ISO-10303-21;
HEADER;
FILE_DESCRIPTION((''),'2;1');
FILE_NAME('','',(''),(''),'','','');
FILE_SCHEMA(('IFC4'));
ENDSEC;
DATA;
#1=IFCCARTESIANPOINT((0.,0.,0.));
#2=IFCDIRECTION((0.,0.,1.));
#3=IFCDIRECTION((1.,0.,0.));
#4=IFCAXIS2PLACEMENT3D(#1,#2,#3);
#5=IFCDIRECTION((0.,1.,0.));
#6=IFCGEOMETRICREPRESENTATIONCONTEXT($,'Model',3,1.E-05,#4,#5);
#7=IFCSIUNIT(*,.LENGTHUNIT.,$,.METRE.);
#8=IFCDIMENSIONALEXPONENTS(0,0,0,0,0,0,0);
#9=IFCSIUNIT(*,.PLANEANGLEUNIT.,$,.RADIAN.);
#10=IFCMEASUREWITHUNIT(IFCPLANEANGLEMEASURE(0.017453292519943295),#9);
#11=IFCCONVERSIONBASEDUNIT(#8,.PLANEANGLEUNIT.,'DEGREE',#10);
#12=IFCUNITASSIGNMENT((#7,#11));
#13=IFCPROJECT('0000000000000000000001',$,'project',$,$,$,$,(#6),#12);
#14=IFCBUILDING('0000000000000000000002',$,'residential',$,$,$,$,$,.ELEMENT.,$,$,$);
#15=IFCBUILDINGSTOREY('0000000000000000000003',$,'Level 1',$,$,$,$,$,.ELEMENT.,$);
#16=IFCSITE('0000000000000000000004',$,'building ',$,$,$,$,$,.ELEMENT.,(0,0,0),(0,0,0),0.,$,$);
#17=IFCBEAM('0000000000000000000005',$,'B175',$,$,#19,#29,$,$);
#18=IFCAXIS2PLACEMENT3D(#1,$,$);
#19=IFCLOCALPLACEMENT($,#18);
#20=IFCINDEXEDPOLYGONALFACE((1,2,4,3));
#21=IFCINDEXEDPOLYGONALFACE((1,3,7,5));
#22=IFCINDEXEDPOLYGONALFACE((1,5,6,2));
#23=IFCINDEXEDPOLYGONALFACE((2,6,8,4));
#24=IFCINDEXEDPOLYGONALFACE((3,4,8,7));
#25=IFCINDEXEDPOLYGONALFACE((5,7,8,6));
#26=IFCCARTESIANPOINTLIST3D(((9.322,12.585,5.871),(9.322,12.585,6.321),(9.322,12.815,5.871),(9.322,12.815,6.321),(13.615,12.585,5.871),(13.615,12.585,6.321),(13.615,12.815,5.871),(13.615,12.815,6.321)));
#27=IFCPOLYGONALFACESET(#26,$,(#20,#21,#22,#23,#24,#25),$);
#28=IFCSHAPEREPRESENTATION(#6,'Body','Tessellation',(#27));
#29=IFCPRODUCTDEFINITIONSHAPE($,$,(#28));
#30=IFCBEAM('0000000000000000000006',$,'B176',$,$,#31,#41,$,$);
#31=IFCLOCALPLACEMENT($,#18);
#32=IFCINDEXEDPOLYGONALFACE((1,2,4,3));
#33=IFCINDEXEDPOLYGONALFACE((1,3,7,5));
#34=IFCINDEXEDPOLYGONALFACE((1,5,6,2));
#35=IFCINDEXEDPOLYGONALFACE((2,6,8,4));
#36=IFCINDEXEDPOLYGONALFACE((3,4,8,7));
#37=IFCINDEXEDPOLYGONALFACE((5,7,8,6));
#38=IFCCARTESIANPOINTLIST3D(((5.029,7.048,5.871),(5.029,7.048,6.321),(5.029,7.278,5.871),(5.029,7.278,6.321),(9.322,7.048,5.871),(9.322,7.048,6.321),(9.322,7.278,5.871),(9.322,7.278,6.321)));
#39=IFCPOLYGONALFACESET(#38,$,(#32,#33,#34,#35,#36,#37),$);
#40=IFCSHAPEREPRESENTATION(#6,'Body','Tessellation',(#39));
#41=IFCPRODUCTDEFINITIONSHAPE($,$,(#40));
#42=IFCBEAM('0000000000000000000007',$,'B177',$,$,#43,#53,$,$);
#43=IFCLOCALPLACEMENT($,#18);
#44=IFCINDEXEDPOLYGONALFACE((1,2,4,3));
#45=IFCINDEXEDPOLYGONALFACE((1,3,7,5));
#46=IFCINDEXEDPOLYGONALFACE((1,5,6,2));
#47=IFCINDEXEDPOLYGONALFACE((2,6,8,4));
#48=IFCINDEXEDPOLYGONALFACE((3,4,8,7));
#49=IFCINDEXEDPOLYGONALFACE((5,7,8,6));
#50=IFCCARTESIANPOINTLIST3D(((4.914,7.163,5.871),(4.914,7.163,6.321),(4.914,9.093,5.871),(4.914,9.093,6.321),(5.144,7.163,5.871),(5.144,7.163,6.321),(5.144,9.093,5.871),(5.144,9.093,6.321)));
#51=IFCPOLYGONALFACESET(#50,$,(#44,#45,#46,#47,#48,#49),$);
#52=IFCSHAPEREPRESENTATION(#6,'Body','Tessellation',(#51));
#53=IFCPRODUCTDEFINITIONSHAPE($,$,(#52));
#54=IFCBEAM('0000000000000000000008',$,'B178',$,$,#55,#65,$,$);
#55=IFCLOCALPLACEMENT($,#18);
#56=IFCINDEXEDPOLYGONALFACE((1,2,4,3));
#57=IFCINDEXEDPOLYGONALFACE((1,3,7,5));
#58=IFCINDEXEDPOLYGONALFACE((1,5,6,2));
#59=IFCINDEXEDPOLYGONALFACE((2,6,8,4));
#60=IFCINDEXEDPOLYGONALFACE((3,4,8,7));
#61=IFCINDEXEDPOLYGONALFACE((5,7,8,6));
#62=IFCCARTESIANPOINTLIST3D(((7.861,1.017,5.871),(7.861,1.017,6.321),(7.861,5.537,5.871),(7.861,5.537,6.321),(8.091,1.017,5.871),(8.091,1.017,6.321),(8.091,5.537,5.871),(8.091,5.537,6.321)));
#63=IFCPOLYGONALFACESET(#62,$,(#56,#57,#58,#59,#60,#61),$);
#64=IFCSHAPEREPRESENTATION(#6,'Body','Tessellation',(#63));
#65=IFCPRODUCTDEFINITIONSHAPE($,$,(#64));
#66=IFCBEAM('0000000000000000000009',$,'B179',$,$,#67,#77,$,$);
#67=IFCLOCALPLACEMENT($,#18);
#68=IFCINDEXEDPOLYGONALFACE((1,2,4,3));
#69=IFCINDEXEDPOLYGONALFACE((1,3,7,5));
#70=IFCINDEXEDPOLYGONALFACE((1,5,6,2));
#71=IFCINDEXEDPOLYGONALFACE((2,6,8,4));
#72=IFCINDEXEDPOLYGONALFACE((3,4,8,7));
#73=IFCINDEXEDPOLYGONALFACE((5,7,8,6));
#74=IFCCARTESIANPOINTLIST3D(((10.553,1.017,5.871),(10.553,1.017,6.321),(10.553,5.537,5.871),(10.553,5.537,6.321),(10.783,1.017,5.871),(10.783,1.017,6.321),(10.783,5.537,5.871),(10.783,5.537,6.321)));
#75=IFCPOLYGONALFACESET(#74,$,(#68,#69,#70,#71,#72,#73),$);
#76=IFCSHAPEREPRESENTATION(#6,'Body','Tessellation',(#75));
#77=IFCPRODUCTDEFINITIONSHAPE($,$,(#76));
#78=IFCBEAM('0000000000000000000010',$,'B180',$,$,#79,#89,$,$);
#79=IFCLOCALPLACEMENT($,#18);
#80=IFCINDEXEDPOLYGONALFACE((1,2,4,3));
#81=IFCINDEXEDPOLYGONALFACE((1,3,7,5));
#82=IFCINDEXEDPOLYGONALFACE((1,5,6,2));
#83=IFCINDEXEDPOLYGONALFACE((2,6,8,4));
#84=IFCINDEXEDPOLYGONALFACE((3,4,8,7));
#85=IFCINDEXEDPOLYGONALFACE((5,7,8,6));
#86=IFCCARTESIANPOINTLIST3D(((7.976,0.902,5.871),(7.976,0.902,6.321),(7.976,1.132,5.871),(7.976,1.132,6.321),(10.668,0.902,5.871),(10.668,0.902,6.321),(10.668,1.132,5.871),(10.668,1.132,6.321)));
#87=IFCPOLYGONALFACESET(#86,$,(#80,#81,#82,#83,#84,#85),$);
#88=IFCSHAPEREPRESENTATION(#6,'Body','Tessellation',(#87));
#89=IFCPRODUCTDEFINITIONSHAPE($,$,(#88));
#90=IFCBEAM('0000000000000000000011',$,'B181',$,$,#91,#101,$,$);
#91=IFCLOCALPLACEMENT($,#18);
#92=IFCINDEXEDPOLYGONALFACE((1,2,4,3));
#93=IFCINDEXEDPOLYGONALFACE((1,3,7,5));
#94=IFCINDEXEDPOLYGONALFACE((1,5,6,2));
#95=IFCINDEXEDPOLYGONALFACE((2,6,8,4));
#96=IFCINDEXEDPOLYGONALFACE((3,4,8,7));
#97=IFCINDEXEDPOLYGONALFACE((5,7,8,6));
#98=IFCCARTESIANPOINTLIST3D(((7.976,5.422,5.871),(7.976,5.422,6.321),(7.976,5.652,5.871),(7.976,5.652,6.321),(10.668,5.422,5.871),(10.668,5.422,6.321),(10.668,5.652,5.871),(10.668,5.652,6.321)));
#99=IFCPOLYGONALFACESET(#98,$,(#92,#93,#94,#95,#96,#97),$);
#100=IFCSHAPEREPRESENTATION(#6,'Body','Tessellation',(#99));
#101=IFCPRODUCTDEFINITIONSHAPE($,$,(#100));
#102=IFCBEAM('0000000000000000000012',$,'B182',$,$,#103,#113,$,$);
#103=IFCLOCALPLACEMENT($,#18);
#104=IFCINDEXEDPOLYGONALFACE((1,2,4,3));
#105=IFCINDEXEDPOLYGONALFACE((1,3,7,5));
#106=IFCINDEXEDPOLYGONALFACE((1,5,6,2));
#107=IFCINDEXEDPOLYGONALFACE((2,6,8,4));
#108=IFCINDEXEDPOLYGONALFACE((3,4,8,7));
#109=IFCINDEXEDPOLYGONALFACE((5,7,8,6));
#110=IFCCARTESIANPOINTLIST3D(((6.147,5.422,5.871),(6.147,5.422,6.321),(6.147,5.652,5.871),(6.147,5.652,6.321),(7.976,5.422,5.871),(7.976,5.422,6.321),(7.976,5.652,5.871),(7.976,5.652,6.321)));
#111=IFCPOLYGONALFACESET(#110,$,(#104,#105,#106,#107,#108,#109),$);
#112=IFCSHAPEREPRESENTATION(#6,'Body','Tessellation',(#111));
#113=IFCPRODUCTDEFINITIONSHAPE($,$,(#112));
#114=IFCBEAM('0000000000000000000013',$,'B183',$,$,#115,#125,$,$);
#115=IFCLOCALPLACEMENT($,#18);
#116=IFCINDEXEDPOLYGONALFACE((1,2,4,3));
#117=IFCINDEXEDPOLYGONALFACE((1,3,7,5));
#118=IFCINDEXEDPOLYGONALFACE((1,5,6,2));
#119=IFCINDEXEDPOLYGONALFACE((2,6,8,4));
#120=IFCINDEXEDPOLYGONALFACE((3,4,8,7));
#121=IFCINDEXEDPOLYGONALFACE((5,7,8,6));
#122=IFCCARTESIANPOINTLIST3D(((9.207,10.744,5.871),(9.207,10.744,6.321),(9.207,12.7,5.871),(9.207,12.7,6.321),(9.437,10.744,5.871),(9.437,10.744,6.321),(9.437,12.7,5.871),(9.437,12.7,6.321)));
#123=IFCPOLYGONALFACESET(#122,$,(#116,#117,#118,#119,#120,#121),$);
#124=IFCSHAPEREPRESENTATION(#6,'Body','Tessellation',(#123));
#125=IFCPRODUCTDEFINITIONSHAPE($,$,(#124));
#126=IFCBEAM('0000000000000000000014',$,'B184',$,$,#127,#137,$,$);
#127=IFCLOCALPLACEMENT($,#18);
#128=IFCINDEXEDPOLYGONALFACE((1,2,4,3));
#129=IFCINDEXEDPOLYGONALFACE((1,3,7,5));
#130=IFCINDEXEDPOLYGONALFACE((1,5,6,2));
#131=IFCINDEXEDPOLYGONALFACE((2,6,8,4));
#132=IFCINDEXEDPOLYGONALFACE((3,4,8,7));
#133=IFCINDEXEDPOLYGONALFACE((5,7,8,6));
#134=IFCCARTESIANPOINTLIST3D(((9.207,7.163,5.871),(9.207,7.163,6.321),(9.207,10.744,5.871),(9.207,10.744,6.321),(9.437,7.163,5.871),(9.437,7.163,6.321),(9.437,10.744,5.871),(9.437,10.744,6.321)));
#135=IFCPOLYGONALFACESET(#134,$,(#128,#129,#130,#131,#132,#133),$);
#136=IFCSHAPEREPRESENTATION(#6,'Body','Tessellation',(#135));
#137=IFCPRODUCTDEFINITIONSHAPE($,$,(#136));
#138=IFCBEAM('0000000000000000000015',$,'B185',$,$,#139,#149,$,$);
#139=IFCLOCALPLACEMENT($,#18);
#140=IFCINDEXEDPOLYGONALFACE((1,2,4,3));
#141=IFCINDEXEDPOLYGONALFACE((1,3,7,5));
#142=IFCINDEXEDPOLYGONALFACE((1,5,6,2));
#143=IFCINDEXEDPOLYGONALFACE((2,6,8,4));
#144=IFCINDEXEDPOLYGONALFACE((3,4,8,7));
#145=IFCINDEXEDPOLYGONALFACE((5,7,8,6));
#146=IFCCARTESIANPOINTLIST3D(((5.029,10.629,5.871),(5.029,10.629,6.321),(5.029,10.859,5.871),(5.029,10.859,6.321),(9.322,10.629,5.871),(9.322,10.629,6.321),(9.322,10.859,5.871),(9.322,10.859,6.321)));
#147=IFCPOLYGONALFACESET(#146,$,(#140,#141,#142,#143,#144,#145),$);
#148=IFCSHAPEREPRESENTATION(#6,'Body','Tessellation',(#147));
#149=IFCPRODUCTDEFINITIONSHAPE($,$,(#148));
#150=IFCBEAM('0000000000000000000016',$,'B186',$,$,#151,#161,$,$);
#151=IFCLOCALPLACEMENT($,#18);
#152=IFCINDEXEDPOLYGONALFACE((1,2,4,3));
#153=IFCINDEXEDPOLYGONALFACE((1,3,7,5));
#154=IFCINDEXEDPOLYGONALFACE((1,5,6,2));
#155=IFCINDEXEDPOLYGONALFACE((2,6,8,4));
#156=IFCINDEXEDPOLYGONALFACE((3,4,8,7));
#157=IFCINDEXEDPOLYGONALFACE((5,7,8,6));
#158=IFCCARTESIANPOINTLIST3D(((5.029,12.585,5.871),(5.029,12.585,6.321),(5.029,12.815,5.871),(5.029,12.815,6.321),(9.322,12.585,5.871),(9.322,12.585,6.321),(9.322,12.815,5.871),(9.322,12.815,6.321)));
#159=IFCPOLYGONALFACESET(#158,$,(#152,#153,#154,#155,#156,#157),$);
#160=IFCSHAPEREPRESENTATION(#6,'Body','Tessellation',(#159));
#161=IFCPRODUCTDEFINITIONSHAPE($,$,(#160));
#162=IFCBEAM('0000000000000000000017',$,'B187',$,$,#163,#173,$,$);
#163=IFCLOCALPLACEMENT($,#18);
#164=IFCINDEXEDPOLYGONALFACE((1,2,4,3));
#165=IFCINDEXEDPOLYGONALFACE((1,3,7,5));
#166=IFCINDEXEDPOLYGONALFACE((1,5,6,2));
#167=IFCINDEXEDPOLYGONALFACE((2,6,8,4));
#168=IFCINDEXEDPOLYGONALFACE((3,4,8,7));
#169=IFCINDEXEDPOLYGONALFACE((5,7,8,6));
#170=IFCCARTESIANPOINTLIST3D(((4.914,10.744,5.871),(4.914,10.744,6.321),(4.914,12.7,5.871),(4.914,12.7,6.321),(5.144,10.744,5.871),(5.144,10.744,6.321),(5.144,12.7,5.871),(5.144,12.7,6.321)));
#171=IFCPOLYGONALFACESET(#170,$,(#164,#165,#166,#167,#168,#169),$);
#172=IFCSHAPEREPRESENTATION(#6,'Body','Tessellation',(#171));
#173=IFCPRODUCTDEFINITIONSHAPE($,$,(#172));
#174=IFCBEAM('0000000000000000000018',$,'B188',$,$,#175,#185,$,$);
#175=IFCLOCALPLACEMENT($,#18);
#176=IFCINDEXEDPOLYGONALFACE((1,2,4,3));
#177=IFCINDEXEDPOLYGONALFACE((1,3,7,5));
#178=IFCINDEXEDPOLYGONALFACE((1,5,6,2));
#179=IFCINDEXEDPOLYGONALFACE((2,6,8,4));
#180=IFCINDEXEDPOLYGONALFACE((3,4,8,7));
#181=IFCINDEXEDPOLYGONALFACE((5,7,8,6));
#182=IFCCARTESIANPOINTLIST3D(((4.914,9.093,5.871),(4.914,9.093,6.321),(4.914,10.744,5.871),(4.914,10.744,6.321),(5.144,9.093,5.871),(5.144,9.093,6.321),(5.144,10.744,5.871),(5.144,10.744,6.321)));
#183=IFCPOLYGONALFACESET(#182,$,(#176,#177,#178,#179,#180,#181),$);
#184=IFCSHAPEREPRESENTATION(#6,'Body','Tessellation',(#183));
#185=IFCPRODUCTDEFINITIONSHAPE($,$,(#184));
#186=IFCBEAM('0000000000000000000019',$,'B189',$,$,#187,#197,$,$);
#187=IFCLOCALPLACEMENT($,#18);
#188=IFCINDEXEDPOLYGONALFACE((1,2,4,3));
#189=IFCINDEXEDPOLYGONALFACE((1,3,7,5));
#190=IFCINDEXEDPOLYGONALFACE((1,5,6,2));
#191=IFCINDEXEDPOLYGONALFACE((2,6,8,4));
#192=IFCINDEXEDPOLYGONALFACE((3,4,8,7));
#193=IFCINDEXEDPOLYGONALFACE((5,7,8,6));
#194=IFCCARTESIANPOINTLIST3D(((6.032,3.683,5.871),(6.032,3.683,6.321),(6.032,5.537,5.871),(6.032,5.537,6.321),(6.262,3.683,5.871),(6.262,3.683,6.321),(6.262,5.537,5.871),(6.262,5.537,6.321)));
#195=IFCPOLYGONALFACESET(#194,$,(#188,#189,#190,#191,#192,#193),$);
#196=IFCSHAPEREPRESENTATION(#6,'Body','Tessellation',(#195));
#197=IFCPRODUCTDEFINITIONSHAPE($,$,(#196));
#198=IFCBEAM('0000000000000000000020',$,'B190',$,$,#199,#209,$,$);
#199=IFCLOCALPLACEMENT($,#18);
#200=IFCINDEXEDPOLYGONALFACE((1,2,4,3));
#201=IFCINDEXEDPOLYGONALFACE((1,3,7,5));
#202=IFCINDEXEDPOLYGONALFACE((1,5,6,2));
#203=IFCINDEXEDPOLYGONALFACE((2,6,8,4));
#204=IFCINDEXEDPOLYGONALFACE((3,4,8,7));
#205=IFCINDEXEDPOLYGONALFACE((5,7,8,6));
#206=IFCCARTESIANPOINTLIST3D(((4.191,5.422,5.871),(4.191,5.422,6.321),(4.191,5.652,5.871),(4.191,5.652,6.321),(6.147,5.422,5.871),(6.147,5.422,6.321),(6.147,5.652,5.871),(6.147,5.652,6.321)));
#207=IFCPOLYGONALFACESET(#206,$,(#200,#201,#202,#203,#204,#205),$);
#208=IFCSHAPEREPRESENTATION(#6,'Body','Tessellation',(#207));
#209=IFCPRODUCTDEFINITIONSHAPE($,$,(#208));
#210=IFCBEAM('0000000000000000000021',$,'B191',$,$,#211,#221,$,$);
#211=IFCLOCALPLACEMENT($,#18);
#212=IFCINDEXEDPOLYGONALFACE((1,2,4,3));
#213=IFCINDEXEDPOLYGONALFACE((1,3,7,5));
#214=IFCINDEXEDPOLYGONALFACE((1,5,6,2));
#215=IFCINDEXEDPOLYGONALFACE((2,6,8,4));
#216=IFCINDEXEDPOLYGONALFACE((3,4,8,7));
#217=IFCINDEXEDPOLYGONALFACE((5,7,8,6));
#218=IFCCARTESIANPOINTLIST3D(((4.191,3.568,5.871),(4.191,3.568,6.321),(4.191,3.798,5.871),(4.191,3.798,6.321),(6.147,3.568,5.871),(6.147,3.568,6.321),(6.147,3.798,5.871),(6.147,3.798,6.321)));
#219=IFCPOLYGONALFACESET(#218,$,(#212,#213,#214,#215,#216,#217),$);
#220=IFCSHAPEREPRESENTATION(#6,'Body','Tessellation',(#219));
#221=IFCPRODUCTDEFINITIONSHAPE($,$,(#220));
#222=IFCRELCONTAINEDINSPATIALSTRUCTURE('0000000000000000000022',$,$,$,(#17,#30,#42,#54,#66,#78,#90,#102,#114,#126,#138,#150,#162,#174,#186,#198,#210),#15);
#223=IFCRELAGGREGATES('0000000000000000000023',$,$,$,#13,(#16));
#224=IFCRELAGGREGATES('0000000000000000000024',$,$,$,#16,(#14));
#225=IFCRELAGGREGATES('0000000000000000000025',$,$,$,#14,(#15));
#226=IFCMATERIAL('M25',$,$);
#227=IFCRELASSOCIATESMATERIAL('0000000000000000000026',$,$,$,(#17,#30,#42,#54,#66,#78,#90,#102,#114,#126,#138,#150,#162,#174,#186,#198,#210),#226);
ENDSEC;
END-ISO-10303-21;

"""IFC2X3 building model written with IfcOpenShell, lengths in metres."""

from ifc_helpers import new_model, entity, si_unit, converted_unit, direction, frame, frame_2d, origin_with_axes, place, context, project, spatial, rectangle, extrude, material, element, save


model = new_model("IFC2X3")

# Units and contexts
model_context = context("Model", 3, precision=1e-05, world=origin_with_axes(), true_north=direction((0.0, 1.0, 0.0)))
ifc_project = project(units=[si_unit("LENGTHUNIT", "METRE"), converted_unit("PLANEANGLEUNIT", "DEGREE", entity("IfcPlaneAngleMeasure", 0.017453292519943295), si_unit("PLANEANGLEUNIT", "RADIAN"), dimensions=[0, 0, 0, 0, 0, 0, 0])], contexts=[model_context])

# Site, building, storey
site = spatial("IfcSite", under=ifc_project, Name="building ", CompositionType="ELEMENT", RefLatitude=(0, 0, 0), RefLongitude=(0, 0, 0), RefElevation=0.0)
building = spatial("IfcBuilding", under=site, Name="residential", CompositionType="ELEMENT")
storey = spatial("IfcBuildingStorey", under=building, Name="Level 1", CompositionType="ELEMENT")

# Beams
ifc_material = material(Name="M25")
placement = place(None, origin_with_axes())
element("IfcBeam", 1, at=placement, inside=storey, material=ifc_material, Name="B175", context=model_context, shape_type="SweptSolid", body=[
    extrude(rectangle(XDim=0.23, YDim=0.45, at=frame_2d((0.0, 0.0), x_axis=(0.0, 1.0, 0.0))), frame((9.322, 12.7, 6.096), z_axis=(1.0, 0.0, 0.0), x_axis=(0.0, 0.0, -1.0)), (0.0, 0.0, 1.0), 4.293),
])
element("IfcBeam", 2, at=placement, inside=storey, material=ifc_material, Name="B176", context=model_context, shape_type="SweptSolid", body=[
    extrude(rectangle(XDim=0.23, YDim=0.45, at=frame_2d((0.0, 0.0), x_axis=(0.0, 1.0, 0.0))), frame((5.029, 7.163, 6.096), z_axis=(1.0, 0.0, 0.0), x_axis=(0.0, 0.0, -1.0)), (0.0, 0.0, 1.0), 4.293),
])
element("IfcBeam", 3, at=placement, inside=storey, material=ifc_material, Name="B177", context=model_context, shape_type="SweptSolid", body=[
    extrude(rectangle(XDim=0.23, YDim=0.45, at=frame_2d((0.0, 0.0), x_axis=(0.0, 1.0, 0.0))), frame((5.029, 9.093, 6.096), z_axis=(0.0, -1.0, 0.0), x_axis=(0.0, 0.0, -1.0)), (0.0, 0.0, 1.0), 1.93),
])
element("IfcBeam", 4, at=placement, inside=storey, material=ifc_material, Name="B178", context=model_context, shape_type="SweptSolid", body=[
    extrude(rectangle(XDim=0.23, YDim=0.45, at=frame_2d((0.0, 0.0), x_axis=(0.0, 1.0, 0.0))), frame((7.976, 1.017, 6.096), z_axis=(0.0, 1.0, 0.0), x_axis=(0.0, 0.0, -1.0)), (0.0, 0.0, 1.0), 4.52),
])
element("IfcBeam", 5, at=placement, inside=storey, material=ifc_material, Name="B179", context=model_context, shape_type="SweptSolid", body=[
    extrude(rectangle(XDim=0.23, YDim=0.45, at=frame_2d((0.0, 0.0), x_axis=(0.0, 1.0, 0.0))), frame((10.668, 1.017, 6.096), z_axis=(0.0, 1.0, 0.0), x_axis=(0.0, 0.0, -1.0)), (0.0, 0.0, 1.0), 4.52),
])
element("IfcBeam", 6, at=placement, inside=storey, material=ifc_material, Name="B180", context=model_context, shape_type="SweptSolid", body=[
    extrude(rectangle(XDim=0.23, YDim=0.45, at=frame_2d((0.0, 0.0), x_axis=(0.0, 1.0, 0.0))), frame((7.976, 1.017, 6.096), z_axis=(1.0, 0.0, 0.0), x_axis=(0.0, 0.0, -1.0)), (0.0, 0.0, 1.0), 2.692),
])
element("IfcBeam", 7, at=placement, inside=storey, material=ifc_material, Name="B181", context=model_context, shape_type="SweptSolid", body=[
    extrude(rectangle(XDim=0.23, YDim=0.45, at=frame_2d((0.0, 0.0), x_axis=(0.0, 1.0, 0.0))), frame((7.976, 5.537, 6.096), z_axis=(1.0, 0.0, 0.0), x_axis=(0.0, 0.0, -1.0)), (0.0, 0.0, 1.0), 2.692),
])
element("IfcBeam", 8, at=placement, inside=storey, material=ifc_material, Name="B182", context=model_context, shape_type="SweptSolid", body=[
    extrude(rectangle(XDim=0.23, YDim=0.45, at=frame_2d((0.0, 0.0), x_axis=(0.0, 1.0, 0.0))), frame((6.147, 5.537, 6.096), z_axis=(1.0, 0.0, 0.0), x_axis=(0.0, 0.0, -1.0)), (0.0, 0.0, 1.0), 1.829),
])
element("IfcBeam", 9, at=placement, inside=storey, material=ifc_material, Name="B183", context=model_context, shape_type="SweptSolid", body=[
    extrude(rectangle(XDim=0.23, YDim=0.45, at=frame_2d((0.0, 0.0), x_axis=(0.0, 1.0, 0.0))), frame((9.322, 10.744, 6.096), z_axis=(0.0, 1.0, 0.0), x_axis=(0.0, 0.0, -1.0)), (0.0, 0.0, 1.0), 1.956),
])
element("IfcBeam", 10, at=placement, inside=storey, material=ifc_material, Name="B184", context=model_context, shape_type="SweptSolid", body=[
    extrude(rectangle(XDim=0.23, YDim=0.45, at=frame_2d((0.0, 0.0), x_axis=(0.0, 1.0, 0.0))), frame((9.322, 7.163, 6.096), z_axis=(0.0, 1.0, 0.0), x_axis=(0.0, 0.0, -1.0)), (0.0, 0.0, 1.0), 3.581),
])
element("IfcBeam", 11, at=placement, inside=storey, material=ifc_material, Name="B185", context=model_context, shape_type="SweptSolid", body=[
    extrude(rectangle(XDim=0.23, YDim=0.45, at=frame_2d((0.0, 0.0), x_axis=(0.0, 1.0, 0.0))), frame((5.029, 10.744, 6.096), z_axis=(1.0, 0.0, 0.0), x_axis=(0.0, 0.0, -1.0)), (0.0, 0.0, 1.0), 4.293),
])
element("IfcBeam", 12, at=placement, inside=storey, material=ifc_material, Name="B186", context=model_context, shape_type="SweptSolid", body=[
    extrude(rectangle(XDim=0.23, YDim=0.45, at=frame_2d((0.0, 0.0), x_axis=(0.0, 1.0, 0.0))), frame((5.029, 12.7, 6.096), z_axis=(1.0, 0.0, 0.0), x_axis=(0.0, 0.0, -1.0)), (0.0, 0.0, 1.0), 4.293),
])
element("IfcBeam", 13, at=placement, inside=storey, material=ifc_material, Name="B187", context=model_context, shape_type="SweptSolid", body=[
    extrude(rectangle(XDim=0.23, YDim=0.45, at=frame_2d((0.0, 0.0), x_axis=(0.0, 1.0, 0.0))), frame((5.029, 10.744, 6.096), z_axis=(0.0, 1.0, 0.0), x_axis=(0.0, 0.0, -1.0)), (0.0, 0.0, 1.0), 1.956),
])
element("IfcBeam", 14, at=placement, inside=storey, material=ifc_material, Name="B188", context=model_context, shape_type="SweptSolid", body=[
    extrude(rectangle(XDim=0.23, YDim=0.45, at=frame_2d((0.0, 0.0), x_axis=(0.0, 1.0, 0.0))), frame((5.029, 9.093, 6.096), z_axis=(0.0, 1.0, 0.0), x_axis=(0.0, 0.0, -1.0)), (0.0, 0.0, 1.0), 1.651),
])
element("IfcBeam", 15, at=placement, inside=storey, material=ifc_material, Name="B189", context=model_context, shape_type="SweptSolid", body=[
    extrude(rectangle(XDim=0.23, YDim=0.45, at=frame_2d((0.0, 0.0), x_axis=(0.0, 1.0, 0.0))), frame((6.147, 3.683, 6.096), z_axis=(0.0, 1.0, 0.0), x_axis=(0.0, 0.0, -1.0)), (0.0, 0.0, 1.0), 1.854),
])
element("IfcBeam", 16, at=placement, inside=storey, material=ifc_material, Name="B190", context=model_context, shape_type="SweptSolid", body=[
    extrude(rectangle(XDim=0.23, YDim=0.45, at=frame_2d((0.0, 0.0), x_axis=(0.0, 1.0, 0.0))), frame((4.191, 5.537, 6.096), z_axis=(1.0, 0.0, 0.0), x_axis=(0.0, 0.0, -1.0)), (0.0, 0.0, 1.0), 1.956),
])
element("IfcBeam", 17, at=placement, inside=storey, material=ifc_material, Name="B191", context=model_context, shape_type="SweptSolid", body=[
    extrude(rectangle(XDim=0.23, YDim=0.45, at=frame_2d((0.0, 0.0), x_axis=(0.0, 1.0, 0.0))), frame((4.191, 3.683, 6.096), z_axis=(1.0, 0.0, 0.0), x_axis=(0.0, 0.0, -1.0)), (0.0, 0.0, 1.0), 1.956),
])

save(model, "model.ifc")
